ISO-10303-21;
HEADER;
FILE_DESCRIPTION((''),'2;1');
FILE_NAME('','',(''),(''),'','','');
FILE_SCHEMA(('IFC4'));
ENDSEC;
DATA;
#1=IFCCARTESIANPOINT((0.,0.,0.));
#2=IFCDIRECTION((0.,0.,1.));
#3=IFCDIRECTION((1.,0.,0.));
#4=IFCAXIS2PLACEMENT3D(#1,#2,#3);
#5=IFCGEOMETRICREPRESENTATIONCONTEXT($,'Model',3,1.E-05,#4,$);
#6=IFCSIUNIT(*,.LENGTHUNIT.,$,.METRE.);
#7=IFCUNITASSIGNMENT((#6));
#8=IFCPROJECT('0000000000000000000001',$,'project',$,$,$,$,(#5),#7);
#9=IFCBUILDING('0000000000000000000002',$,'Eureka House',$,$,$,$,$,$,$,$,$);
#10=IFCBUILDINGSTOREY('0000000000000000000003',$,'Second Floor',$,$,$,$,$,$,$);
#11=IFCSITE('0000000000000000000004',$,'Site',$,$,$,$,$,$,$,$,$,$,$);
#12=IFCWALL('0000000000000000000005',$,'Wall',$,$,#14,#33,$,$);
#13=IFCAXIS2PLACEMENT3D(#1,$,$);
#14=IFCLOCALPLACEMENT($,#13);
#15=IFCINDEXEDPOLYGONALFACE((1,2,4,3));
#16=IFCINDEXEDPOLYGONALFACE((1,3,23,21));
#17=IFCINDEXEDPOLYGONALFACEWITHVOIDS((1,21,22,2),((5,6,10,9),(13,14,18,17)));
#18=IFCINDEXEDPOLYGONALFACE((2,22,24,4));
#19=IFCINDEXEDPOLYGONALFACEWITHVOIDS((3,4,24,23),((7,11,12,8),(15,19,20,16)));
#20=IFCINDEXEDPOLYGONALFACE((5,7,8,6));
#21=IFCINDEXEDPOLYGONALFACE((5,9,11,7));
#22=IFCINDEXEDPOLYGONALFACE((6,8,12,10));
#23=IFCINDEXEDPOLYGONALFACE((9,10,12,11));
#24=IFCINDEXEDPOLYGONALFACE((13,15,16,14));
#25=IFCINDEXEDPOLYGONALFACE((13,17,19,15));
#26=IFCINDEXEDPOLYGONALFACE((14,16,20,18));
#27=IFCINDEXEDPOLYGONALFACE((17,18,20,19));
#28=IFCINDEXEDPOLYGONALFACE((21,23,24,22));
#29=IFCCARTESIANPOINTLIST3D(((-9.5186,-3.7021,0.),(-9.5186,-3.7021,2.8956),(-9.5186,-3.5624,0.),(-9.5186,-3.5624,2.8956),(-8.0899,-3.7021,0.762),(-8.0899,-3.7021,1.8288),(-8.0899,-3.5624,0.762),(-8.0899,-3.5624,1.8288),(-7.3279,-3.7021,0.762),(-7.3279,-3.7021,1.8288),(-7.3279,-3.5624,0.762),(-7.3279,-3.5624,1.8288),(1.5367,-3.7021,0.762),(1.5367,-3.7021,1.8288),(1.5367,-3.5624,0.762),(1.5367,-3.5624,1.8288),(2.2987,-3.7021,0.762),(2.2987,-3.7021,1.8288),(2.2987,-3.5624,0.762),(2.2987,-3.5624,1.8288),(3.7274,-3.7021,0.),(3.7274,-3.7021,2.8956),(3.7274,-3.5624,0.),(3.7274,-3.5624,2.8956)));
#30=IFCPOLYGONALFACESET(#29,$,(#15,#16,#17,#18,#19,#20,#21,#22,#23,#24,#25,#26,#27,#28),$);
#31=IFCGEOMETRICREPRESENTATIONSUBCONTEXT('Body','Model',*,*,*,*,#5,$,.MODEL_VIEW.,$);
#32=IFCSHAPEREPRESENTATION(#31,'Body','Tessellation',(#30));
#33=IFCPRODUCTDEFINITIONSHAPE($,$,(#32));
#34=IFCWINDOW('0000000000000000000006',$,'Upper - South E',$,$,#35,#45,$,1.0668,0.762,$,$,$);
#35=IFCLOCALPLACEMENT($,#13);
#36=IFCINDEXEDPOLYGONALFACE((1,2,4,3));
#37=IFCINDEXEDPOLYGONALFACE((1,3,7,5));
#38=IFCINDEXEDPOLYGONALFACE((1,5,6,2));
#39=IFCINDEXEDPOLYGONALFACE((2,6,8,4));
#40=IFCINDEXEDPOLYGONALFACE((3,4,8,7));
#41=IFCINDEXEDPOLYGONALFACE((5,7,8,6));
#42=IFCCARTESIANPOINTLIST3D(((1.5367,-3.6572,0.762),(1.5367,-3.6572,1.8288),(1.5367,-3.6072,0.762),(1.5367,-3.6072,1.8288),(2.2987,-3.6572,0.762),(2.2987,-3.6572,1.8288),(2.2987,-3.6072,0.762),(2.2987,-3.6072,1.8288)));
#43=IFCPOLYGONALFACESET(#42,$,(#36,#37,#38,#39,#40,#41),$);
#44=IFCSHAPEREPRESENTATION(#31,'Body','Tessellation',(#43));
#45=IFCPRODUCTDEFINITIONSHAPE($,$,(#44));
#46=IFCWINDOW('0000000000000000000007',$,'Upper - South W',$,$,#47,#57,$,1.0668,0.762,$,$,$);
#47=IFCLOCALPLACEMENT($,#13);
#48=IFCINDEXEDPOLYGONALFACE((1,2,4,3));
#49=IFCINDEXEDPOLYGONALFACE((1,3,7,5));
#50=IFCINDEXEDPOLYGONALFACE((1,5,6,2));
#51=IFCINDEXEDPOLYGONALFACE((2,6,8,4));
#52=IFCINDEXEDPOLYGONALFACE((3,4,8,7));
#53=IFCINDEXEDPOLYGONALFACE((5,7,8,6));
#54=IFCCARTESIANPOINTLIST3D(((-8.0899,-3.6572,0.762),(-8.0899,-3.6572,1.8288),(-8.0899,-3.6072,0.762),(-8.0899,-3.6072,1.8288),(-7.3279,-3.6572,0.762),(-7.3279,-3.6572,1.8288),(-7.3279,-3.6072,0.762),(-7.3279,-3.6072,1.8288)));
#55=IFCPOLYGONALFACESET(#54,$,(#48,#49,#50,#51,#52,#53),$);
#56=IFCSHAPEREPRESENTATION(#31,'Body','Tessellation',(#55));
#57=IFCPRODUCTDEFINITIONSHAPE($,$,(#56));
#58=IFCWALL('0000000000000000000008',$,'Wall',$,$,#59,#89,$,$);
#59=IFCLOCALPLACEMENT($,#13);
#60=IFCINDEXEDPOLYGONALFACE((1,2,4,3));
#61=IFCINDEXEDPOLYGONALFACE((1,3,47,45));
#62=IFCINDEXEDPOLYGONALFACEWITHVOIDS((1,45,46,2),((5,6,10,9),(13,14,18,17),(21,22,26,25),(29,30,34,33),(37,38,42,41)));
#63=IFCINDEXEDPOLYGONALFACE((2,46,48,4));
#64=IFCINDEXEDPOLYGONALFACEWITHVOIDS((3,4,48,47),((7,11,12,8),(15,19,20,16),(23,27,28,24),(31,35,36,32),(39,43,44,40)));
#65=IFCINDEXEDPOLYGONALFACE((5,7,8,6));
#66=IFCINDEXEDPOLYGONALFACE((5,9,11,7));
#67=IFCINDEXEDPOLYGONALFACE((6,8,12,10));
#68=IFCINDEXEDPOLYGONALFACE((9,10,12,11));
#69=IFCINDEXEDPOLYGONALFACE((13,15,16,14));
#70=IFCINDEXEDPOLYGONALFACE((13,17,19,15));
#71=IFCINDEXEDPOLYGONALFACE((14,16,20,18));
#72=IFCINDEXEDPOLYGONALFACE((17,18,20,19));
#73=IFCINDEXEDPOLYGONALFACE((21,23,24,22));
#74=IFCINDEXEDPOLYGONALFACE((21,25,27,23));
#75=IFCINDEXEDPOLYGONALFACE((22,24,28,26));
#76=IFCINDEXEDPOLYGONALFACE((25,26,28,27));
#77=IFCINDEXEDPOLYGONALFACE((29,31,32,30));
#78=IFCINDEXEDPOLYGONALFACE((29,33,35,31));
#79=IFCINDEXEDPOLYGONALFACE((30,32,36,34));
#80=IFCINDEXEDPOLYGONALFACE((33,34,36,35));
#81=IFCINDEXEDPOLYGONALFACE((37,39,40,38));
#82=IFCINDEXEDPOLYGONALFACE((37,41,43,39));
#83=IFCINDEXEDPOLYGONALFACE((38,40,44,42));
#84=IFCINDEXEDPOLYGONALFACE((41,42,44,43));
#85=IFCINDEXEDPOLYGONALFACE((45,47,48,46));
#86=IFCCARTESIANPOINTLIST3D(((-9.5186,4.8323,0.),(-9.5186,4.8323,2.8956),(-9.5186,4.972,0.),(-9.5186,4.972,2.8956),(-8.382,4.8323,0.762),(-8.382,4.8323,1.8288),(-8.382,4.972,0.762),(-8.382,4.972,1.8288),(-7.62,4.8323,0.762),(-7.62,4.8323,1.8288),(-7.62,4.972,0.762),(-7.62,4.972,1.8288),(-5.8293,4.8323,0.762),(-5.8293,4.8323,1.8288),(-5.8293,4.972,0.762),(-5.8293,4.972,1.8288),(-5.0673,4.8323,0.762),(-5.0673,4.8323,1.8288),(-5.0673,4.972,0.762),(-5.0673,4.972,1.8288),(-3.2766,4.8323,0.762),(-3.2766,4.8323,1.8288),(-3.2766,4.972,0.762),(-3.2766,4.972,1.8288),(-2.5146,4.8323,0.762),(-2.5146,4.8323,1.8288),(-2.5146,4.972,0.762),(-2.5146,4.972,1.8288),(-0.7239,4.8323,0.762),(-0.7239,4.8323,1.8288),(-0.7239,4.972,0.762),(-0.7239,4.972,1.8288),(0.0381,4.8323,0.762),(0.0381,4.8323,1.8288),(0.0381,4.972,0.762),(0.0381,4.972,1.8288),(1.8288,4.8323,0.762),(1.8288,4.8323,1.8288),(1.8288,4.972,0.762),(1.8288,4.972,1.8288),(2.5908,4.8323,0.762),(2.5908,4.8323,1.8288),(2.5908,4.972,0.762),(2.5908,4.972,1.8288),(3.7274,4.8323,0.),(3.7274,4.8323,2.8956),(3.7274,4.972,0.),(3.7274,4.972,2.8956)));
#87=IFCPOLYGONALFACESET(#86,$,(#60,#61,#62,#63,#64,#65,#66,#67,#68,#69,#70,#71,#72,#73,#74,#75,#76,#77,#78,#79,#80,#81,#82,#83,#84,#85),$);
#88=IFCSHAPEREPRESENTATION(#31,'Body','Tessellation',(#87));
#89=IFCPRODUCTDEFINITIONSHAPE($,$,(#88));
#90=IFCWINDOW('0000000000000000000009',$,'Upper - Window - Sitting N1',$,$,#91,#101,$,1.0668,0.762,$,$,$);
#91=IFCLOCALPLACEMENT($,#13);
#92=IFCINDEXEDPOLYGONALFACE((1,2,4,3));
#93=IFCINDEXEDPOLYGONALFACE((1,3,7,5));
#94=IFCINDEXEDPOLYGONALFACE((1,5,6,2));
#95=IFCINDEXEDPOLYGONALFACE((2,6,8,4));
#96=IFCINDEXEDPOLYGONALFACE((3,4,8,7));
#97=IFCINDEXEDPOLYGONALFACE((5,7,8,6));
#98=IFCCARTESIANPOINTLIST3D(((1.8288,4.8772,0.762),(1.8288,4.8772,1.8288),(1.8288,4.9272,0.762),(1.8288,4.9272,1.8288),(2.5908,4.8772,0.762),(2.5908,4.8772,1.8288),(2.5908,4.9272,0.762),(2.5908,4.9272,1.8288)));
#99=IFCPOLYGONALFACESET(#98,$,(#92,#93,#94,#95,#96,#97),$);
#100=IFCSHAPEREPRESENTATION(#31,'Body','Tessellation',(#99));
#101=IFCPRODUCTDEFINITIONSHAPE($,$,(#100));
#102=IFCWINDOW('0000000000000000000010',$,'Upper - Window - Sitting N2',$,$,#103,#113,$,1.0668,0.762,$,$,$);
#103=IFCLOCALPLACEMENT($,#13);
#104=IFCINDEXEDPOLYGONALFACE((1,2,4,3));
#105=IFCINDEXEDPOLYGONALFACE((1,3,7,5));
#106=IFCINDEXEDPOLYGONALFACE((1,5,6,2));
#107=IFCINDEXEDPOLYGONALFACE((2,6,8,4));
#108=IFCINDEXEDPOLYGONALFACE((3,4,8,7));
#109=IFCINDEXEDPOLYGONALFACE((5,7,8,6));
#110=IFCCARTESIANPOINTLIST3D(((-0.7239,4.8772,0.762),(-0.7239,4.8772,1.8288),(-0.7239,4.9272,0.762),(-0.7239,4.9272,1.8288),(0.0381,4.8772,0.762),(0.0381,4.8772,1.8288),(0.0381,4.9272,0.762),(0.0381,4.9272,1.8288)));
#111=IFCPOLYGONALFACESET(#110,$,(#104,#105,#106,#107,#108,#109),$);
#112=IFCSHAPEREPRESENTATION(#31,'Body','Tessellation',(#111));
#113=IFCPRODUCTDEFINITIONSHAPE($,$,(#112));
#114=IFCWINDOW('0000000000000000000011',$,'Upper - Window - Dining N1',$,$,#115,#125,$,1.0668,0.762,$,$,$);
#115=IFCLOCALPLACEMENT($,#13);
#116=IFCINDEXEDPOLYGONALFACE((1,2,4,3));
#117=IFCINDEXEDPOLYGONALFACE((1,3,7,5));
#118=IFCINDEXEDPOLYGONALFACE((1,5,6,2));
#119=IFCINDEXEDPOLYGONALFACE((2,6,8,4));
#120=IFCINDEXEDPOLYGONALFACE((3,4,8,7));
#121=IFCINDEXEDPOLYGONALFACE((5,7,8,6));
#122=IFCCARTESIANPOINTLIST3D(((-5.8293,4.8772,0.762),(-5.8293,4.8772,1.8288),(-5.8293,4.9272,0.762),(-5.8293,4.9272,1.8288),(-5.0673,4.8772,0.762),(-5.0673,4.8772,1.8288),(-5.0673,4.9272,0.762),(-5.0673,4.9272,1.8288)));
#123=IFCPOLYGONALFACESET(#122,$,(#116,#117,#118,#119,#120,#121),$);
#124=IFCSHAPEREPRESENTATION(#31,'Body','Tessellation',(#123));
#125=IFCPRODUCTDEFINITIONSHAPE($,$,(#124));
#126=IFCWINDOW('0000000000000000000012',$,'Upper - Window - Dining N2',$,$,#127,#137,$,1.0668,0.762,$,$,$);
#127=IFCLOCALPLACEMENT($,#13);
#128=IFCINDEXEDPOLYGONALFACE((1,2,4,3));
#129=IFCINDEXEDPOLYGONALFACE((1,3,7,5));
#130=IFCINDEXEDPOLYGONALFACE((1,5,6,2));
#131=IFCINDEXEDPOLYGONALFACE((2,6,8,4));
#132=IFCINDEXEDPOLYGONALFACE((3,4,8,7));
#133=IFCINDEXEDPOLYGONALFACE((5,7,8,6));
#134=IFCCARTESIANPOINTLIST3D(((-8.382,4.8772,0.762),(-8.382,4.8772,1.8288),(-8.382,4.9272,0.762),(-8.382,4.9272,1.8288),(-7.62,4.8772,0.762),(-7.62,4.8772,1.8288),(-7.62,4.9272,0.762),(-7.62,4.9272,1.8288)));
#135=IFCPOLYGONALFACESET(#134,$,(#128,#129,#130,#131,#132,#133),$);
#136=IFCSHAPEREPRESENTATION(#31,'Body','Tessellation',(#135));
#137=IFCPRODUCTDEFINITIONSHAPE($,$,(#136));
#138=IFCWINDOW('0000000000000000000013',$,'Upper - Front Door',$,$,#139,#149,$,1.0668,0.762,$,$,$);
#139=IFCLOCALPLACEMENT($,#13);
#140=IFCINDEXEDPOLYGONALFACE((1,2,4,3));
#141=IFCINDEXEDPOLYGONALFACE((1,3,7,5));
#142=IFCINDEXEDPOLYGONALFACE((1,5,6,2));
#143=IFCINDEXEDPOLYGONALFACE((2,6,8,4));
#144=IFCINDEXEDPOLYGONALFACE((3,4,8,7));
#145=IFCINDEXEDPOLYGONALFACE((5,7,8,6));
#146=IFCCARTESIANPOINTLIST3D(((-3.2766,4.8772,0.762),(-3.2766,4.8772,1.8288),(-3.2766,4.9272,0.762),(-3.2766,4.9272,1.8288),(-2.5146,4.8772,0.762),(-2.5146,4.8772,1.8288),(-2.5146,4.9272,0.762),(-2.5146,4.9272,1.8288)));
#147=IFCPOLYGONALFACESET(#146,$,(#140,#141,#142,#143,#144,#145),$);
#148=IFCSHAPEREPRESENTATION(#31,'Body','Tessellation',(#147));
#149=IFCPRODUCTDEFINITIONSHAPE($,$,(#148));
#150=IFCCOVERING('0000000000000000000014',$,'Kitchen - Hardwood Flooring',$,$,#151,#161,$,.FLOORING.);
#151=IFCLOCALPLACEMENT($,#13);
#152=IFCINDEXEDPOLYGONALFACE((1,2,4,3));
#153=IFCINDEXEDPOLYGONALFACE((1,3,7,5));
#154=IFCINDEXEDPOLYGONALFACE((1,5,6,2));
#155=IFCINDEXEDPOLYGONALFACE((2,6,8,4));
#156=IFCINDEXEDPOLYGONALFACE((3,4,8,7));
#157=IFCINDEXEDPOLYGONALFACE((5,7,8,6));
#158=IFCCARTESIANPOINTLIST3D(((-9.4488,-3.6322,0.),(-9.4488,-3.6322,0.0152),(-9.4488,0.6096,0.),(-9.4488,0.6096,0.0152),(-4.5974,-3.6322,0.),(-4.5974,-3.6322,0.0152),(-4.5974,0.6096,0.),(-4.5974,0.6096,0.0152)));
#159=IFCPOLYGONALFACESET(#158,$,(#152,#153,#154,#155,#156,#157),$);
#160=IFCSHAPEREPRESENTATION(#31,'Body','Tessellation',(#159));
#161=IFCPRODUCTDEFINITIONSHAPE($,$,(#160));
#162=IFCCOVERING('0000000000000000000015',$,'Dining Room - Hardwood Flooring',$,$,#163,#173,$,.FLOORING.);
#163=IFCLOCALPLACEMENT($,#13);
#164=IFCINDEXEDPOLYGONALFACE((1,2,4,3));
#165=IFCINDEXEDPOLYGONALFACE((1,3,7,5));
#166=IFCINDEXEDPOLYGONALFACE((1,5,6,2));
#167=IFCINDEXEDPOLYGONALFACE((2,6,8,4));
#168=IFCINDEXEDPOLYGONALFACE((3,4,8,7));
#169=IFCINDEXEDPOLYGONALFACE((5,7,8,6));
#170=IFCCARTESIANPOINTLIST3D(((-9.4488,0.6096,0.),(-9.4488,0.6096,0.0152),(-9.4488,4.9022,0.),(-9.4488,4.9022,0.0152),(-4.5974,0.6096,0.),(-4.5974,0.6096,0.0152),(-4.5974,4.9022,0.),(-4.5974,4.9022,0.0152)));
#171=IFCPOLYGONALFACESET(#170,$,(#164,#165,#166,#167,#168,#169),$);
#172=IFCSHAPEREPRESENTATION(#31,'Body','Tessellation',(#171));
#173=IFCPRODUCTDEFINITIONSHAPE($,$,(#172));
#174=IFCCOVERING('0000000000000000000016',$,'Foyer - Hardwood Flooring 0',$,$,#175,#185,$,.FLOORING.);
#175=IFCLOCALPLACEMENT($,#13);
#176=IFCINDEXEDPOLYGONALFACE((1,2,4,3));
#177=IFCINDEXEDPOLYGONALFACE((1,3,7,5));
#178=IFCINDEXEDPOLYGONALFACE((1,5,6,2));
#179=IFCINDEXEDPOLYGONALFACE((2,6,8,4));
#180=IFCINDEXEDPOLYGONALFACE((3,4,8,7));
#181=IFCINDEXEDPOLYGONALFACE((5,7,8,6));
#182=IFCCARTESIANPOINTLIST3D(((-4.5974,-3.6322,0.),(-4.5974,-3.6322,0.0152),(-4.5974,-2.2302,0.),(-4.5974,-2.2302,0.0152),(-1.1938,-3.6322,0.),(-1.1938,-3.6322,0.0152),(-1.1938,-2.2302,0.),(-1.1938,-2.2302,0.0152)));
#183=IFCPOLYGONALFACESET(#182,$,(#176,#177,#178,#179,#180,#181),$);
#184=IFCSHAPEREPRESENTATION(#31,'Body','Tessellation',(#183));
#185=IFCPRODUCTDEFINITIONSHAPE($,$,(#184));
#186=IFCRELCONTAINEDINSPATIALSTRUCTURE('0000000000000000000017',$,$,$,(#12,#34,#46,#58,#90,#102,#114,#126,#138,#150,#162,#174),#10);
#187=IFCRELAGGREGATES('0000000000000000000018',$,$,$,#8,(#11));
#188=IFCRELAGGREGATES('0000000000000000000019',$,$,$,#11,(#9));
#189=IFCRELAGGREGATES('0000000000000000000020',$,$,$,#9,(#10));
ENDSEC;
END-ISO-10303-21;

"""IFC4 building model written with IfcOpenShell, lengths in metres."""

from ifc_helpers import new_model, si_unit, frame, origin, origin_with_axes, origin_2d, place, context, subcontext, project, spatial, rectangle, extrude, element, fill, save


model = new_model("IFC4")

# Units and contexts
model_context = context("Model", 3, precision=1e-05, world=origin_with_axes())
body_context = subcontext(model_context, "Body", "Model", "MODEL_VIEW")
ifc_project = project(units=[si_unit("LENGTHUNIT", "METRE")], contexts=[model_context])

# Site, building, storey
site = spatial("IfcSite", under=ifc_project, Name="Site")
building = spatial("IfcBuilding", under=site, Name="Eureka House")
storey = spatial("IfcBuildingStorey", under=building, Name="Second Floor")

# Walls, openings, windows
wall_1_placement = place(None, frame((-2.8956, -3.6322, 0.0), z_axis=(0.0, 0.0, 1.0), x_axis=(1.0, 0.0, 0.0)))
wall_1 = element("IfcWall", 1, at=wall_1_placement, inside=storey, Name="Wall", context=body_context, shape_type="SweptSolid", body=[
    extrude(rectangle(XDim=13.2461, YDim=0.1397, at=origin_2d()), origin(), (0.0, 0.0, 1.0), 2.8956),
])
opening_1_placement = place(wall_1_placement, frame((4.8133, 0.0, 0.762), z_axis=(0.0, 0.0, 1.0), x_axis=(1.0, 0.0, 0.0)))
opening_1 = element("IfcOpeningElement", 2, at=opening_1_placement, cuts=wall_1, context=body_context, shape_type="SweptSolid", body=[
    extrude(rectangle(XDim=0.762, YDim=0.2397, at=origin_2d()), origin(), (0.0, 0.0, 1.0), 1.0668),
])
opening_2_placement = place(wall_1_placement, frame((-4.8133, 0.0, 0.762), z_axis=(0.0, 0.0, 1.0), x_axis=(1.0, 0.0, 0.0)))
opening_2 = element("IfcOpeningElement", 3, at=opening_2_placement, cuts=wall_1, context=body_context, shape_type="SweptSolid", body=[
    extrude(rectangle(XDim=0.762, YDim=0.2397, at=origin_2d()), origin(), (0.0, 0.0, 1.0), 1.0668),
])
window_1_placement = place(opening_1_placement, frame((0.0, 0.0, 0.0), z_axis=(0.0, 0.0, 1.0), x_axis=(1.0, 0.0, 0.0)))
window_1 = element("IfcWindow", 4, at=window_1_placement, inside=storey, Name="Upper - South E", OverallHeight=1.0668, OverallWidth=0.762, context=body_context, shape_type="SweptSolid", body=[
    extrude(rectangle(XDim=0.762, YDim=0.05, at=origin_2d()), origin(), (0.0, 0.0, 1.0), 1.0668),
])
fill(opening_1, window_1)
window_2_placement = place(opening_2_placement, origin_with_axes())
window_2 = element("IfcWindow", 5, at=window_2_placement, inside=storey, Name="Upper - South W", OverallHeight=1.0668, OverallWidth=0.762, context=body_context, shape_type="SweptSolid", body=[
    extrude(rectangle(XDim=0.762, YDim=0.05, at=origin_2d()), origin(), (0.0, 0.0, 1.0), 1.0668),
])
fill(opening_2, window_2)
wall_2_placement = place(None, frame((-2.8956, 4.9022, 0.0), z_axis=(0.0, 0.0, 1.0), x_axis=(1.0, 0.0, 0.0)))
wall_2 = element("IfcWall", 6, at=wall_2_placement, inside=storey, Name="Wall", context=body_context, shape_type="SweptSolid", body=[
    extrude(rectangle(XDim=13.2461, YDim=0.1397, at=origin_2d()), origin(), (0.0, 0.0, 1.0), 2.8956),
])
opening_3_placement = place(wall_2_placement, frame((5.1054, 0.0, 0.762), z_axis=(0.0, 0.0, 1.0), x_axis=(1.0, 0.0, 0.0)))
opening_3 = element("IfcOpeningElement", 7, at=opening_3_placement, cuts=wall_2, context=body_context, shape_type="SweptSolid", body=[
    extrude(rectangle(XDim=0.762, YDim=0.2397, at=origin_2d()), origin(), (0.0, 0.0, 1.0), 1.0668),
])
opening_4_placement = place(wall_2_placement, frame((2.5527, 0.0, 0.762), z_axis=(0.0, 0.0, 1.0), x_axis=(1.0, 0.0, 0.0)))
opening_4 = element("IfcOpeningElement", 8, at=opening_4_placement, cuts=wall_2, context=body_context, shape_type="SweptSolid", body=[
    extrude(rectangle(XDim=0.762, YDim=0.2397, at=origin_2d()), origin(), (0.0, 0.0, 1.0), 1.0668),
])
opening_5_placement = place(wall_2_placement, frame((-2.5527, 0.0, 0.762), z_axis=(0.0, 0.0, 1.0), x_axis=(1.0, 0.0, 0.0)))
opening_5 = element("IfcOpeningElement", 9, at=opening_5_placement, cuts=wall_2, context=body_context, shape_type="SweptSolid", body=[
    extrude(rectangle(XDim=0.762, YDim=0.2397, at=origin_2d()), origin(), (0.0, 0.0, 1.0), 1.0668),
])
opening_6_placement = place(wall_2_placement, frame((-5.1054, 0.0, 0.762), z_axis=(0.0, 0.0, 1.0), x_axis=(1.0, 0.0, 0.0)))
opening_6 = element("IfcOpeningElement", 10, at=opening_6_placement, cuts=wall_2, context=body_context, shape_type="SweptSolid", body=[
    extrude(rectangle(XDim=0.762, YDim=0.2397, at=origin_2d()), origin(), (0.0, 0.0, 1.0), 1.0668),
])
opening_7_placement = place(wall_2_placement, frame((0.0, 0.0, 0.762), z_axis=(0.0, 0.0, 1.0), x_axis=(1.0, 0.0, 0.0)))
opening_7 = element("IfcOpeningElement", 11, at=opening_7_placement, cuts=wall_2, context=body_context, shape_type="SweptSolid", body=[
    extrude(rectangle(XDim=0.762, YDim=0.2397, at=origin_2d()), origin(), (0.0, 0.0, 1.0), 1.0668),
])
window_3_placement = place(opening_3_placement, frame((0.0, 0.0, 0.0), z_axis=(0.0, 0.0, 1.0), x_axis=(1.0, 0.0, 0.0)))
window_3 = element("IfcWindow", 12, at=window_3_placement, inside=storey, Name="Upper - Window - Sitting N1", OverallHeight=1.0668, OverallWidth=0.762, context=body_context, shape_type="SweptSolid", body=[
    extrude(rectangle(XDim=0.762, YDim=0.05, at=origin_2d()), origin(), (0.0, 0.0, 1.0), 1.0668),
])
fill(opening_3, window_3)
window_4_placement = place(opening_4_placement, frame((0.0, 0.0, 0.0), z_axis=(0.0, 0.0, 1.0), x_axis=(1.0, 0.0, 0.0)))
window_4 = element("IfcWindow", 13, at=window_4_placement, inside=storey, Name="Upper - Window - Sitting N2", OverallHeight=1.0668, OverallWidth=0.762, context=body_context, shape_type="SweptSolid", body=[
    extrude(rectangle(XDim=0.762, YDim=0.05, at=origin_2d()), origin(), (0.0, 0.0, 1.0), 1.0668),
])
fill(opening_4, window_4)
window_5_placement = place(opening_5_placement, origin_with_axes())
window_5 = element("IfcWindow", 14, at=window_5_placement, inside=storey, Name="Upper - Window - Dining N1", OverallHeight=1.0668, OverallWidth=0.762, context=body_context, shape_type="SweptSolid", body=[
    extrude(rectangle(XDim=0.762, YDim=0.05, at=origin_2d()), origin(), (0.0, 0.0, 1.0), 1.0668),
])
fill(opening_5, window_5)
window_6_placement = place(opening_6_placement, origin_with_axes())
window_6 = element("IfcWindow", 15, at=window_6_placement, inside=storey, Name="Upper - Window - Dining N2", OverallHeight=1.0668, OverallWidth=0.762, context=body_context, shape_type="SweptSolid", body=[
    extrude(rectangle(XDim=0.762, YDim=0.05, at=origin_2d()), origin(), (0.0, 0.0, 1.0), 1.0668),
])
fill(opening_6, window_6)
window_7_placement = place(opening_7_placement, origin_with_axes())
window_7 = element("IfcWindow", 16, at=window_7_placement, inside=storey, Name="Upper - Front Door", OverallHeight=1.0668, OverallWidth=0.762, context=body_context, shape_type="SweptSolid", body=[
    extrude(rectangle(XDim=0.762, YDim=0.05, at=origin_2d()), origin(), (0.0, 0.0, 1.0), 1.0668),
])
fill(opening_7, window_7)

# Coverings
covering_1_placement = place(None, frame((-7.0231, -1.5113, 0.0), z_axis=(0.0, 0.0, 1.0), x_axis=(1.0, 0.0, 0.0)))
element("IfcCovering", 17, at=covering_1_placement, inside=storey, Name="Kitchen - Hardwood Flooring", PredefinedType="FLOORING", context=body_context, shape_type="SweptSolid", body=[
    extrude(rectangle(XDim=4.8514, YDim=4.2418, at=origin_2d()), origin(), (0.0, 0.0, 1.0), 0.0152),
])
covering_2_placement = place(None, frame((-7.0231, 2.7559, 0.0), z_axis=(0.0, 0.0, 1.0), x_axis=(1.0, 0.0, 0.0)))
element("IfcCovering", 18, at=covering_2_placement, inside=storey, Name="Dining Room - Hardwood Flooring", PredefinedType="FLOORING", context=body_context, shape_type="SweptSolid", body=[
    extrude(rectangle(XDim=4.8514, YDim=4.2926, at=origin_2d()), origin(), (0.0, 0.0, 1.0), 0.0152),
])
covering_3_placement = place(None, frame((-2.8956, -2.9312, 0.0), z_axis=(0.0, 0.0, 1.0), x_axis=(1.0, 0.0, 0.0)))
element("IfcCovering", 19, at=covering_3_placement, inside=storey, Name="Foyer - Hardwood Flooring 0", PredefinedType="FLOORING", context=body_context, shape_type="SweptSolid", body=[
    extrude(rectangle(XDim=3.4036, YDim=1.402, at=origin_2d()), origin(), (0.0, 0.0, 1.0), 0.0152),
])

save(model, "model.ifc")
